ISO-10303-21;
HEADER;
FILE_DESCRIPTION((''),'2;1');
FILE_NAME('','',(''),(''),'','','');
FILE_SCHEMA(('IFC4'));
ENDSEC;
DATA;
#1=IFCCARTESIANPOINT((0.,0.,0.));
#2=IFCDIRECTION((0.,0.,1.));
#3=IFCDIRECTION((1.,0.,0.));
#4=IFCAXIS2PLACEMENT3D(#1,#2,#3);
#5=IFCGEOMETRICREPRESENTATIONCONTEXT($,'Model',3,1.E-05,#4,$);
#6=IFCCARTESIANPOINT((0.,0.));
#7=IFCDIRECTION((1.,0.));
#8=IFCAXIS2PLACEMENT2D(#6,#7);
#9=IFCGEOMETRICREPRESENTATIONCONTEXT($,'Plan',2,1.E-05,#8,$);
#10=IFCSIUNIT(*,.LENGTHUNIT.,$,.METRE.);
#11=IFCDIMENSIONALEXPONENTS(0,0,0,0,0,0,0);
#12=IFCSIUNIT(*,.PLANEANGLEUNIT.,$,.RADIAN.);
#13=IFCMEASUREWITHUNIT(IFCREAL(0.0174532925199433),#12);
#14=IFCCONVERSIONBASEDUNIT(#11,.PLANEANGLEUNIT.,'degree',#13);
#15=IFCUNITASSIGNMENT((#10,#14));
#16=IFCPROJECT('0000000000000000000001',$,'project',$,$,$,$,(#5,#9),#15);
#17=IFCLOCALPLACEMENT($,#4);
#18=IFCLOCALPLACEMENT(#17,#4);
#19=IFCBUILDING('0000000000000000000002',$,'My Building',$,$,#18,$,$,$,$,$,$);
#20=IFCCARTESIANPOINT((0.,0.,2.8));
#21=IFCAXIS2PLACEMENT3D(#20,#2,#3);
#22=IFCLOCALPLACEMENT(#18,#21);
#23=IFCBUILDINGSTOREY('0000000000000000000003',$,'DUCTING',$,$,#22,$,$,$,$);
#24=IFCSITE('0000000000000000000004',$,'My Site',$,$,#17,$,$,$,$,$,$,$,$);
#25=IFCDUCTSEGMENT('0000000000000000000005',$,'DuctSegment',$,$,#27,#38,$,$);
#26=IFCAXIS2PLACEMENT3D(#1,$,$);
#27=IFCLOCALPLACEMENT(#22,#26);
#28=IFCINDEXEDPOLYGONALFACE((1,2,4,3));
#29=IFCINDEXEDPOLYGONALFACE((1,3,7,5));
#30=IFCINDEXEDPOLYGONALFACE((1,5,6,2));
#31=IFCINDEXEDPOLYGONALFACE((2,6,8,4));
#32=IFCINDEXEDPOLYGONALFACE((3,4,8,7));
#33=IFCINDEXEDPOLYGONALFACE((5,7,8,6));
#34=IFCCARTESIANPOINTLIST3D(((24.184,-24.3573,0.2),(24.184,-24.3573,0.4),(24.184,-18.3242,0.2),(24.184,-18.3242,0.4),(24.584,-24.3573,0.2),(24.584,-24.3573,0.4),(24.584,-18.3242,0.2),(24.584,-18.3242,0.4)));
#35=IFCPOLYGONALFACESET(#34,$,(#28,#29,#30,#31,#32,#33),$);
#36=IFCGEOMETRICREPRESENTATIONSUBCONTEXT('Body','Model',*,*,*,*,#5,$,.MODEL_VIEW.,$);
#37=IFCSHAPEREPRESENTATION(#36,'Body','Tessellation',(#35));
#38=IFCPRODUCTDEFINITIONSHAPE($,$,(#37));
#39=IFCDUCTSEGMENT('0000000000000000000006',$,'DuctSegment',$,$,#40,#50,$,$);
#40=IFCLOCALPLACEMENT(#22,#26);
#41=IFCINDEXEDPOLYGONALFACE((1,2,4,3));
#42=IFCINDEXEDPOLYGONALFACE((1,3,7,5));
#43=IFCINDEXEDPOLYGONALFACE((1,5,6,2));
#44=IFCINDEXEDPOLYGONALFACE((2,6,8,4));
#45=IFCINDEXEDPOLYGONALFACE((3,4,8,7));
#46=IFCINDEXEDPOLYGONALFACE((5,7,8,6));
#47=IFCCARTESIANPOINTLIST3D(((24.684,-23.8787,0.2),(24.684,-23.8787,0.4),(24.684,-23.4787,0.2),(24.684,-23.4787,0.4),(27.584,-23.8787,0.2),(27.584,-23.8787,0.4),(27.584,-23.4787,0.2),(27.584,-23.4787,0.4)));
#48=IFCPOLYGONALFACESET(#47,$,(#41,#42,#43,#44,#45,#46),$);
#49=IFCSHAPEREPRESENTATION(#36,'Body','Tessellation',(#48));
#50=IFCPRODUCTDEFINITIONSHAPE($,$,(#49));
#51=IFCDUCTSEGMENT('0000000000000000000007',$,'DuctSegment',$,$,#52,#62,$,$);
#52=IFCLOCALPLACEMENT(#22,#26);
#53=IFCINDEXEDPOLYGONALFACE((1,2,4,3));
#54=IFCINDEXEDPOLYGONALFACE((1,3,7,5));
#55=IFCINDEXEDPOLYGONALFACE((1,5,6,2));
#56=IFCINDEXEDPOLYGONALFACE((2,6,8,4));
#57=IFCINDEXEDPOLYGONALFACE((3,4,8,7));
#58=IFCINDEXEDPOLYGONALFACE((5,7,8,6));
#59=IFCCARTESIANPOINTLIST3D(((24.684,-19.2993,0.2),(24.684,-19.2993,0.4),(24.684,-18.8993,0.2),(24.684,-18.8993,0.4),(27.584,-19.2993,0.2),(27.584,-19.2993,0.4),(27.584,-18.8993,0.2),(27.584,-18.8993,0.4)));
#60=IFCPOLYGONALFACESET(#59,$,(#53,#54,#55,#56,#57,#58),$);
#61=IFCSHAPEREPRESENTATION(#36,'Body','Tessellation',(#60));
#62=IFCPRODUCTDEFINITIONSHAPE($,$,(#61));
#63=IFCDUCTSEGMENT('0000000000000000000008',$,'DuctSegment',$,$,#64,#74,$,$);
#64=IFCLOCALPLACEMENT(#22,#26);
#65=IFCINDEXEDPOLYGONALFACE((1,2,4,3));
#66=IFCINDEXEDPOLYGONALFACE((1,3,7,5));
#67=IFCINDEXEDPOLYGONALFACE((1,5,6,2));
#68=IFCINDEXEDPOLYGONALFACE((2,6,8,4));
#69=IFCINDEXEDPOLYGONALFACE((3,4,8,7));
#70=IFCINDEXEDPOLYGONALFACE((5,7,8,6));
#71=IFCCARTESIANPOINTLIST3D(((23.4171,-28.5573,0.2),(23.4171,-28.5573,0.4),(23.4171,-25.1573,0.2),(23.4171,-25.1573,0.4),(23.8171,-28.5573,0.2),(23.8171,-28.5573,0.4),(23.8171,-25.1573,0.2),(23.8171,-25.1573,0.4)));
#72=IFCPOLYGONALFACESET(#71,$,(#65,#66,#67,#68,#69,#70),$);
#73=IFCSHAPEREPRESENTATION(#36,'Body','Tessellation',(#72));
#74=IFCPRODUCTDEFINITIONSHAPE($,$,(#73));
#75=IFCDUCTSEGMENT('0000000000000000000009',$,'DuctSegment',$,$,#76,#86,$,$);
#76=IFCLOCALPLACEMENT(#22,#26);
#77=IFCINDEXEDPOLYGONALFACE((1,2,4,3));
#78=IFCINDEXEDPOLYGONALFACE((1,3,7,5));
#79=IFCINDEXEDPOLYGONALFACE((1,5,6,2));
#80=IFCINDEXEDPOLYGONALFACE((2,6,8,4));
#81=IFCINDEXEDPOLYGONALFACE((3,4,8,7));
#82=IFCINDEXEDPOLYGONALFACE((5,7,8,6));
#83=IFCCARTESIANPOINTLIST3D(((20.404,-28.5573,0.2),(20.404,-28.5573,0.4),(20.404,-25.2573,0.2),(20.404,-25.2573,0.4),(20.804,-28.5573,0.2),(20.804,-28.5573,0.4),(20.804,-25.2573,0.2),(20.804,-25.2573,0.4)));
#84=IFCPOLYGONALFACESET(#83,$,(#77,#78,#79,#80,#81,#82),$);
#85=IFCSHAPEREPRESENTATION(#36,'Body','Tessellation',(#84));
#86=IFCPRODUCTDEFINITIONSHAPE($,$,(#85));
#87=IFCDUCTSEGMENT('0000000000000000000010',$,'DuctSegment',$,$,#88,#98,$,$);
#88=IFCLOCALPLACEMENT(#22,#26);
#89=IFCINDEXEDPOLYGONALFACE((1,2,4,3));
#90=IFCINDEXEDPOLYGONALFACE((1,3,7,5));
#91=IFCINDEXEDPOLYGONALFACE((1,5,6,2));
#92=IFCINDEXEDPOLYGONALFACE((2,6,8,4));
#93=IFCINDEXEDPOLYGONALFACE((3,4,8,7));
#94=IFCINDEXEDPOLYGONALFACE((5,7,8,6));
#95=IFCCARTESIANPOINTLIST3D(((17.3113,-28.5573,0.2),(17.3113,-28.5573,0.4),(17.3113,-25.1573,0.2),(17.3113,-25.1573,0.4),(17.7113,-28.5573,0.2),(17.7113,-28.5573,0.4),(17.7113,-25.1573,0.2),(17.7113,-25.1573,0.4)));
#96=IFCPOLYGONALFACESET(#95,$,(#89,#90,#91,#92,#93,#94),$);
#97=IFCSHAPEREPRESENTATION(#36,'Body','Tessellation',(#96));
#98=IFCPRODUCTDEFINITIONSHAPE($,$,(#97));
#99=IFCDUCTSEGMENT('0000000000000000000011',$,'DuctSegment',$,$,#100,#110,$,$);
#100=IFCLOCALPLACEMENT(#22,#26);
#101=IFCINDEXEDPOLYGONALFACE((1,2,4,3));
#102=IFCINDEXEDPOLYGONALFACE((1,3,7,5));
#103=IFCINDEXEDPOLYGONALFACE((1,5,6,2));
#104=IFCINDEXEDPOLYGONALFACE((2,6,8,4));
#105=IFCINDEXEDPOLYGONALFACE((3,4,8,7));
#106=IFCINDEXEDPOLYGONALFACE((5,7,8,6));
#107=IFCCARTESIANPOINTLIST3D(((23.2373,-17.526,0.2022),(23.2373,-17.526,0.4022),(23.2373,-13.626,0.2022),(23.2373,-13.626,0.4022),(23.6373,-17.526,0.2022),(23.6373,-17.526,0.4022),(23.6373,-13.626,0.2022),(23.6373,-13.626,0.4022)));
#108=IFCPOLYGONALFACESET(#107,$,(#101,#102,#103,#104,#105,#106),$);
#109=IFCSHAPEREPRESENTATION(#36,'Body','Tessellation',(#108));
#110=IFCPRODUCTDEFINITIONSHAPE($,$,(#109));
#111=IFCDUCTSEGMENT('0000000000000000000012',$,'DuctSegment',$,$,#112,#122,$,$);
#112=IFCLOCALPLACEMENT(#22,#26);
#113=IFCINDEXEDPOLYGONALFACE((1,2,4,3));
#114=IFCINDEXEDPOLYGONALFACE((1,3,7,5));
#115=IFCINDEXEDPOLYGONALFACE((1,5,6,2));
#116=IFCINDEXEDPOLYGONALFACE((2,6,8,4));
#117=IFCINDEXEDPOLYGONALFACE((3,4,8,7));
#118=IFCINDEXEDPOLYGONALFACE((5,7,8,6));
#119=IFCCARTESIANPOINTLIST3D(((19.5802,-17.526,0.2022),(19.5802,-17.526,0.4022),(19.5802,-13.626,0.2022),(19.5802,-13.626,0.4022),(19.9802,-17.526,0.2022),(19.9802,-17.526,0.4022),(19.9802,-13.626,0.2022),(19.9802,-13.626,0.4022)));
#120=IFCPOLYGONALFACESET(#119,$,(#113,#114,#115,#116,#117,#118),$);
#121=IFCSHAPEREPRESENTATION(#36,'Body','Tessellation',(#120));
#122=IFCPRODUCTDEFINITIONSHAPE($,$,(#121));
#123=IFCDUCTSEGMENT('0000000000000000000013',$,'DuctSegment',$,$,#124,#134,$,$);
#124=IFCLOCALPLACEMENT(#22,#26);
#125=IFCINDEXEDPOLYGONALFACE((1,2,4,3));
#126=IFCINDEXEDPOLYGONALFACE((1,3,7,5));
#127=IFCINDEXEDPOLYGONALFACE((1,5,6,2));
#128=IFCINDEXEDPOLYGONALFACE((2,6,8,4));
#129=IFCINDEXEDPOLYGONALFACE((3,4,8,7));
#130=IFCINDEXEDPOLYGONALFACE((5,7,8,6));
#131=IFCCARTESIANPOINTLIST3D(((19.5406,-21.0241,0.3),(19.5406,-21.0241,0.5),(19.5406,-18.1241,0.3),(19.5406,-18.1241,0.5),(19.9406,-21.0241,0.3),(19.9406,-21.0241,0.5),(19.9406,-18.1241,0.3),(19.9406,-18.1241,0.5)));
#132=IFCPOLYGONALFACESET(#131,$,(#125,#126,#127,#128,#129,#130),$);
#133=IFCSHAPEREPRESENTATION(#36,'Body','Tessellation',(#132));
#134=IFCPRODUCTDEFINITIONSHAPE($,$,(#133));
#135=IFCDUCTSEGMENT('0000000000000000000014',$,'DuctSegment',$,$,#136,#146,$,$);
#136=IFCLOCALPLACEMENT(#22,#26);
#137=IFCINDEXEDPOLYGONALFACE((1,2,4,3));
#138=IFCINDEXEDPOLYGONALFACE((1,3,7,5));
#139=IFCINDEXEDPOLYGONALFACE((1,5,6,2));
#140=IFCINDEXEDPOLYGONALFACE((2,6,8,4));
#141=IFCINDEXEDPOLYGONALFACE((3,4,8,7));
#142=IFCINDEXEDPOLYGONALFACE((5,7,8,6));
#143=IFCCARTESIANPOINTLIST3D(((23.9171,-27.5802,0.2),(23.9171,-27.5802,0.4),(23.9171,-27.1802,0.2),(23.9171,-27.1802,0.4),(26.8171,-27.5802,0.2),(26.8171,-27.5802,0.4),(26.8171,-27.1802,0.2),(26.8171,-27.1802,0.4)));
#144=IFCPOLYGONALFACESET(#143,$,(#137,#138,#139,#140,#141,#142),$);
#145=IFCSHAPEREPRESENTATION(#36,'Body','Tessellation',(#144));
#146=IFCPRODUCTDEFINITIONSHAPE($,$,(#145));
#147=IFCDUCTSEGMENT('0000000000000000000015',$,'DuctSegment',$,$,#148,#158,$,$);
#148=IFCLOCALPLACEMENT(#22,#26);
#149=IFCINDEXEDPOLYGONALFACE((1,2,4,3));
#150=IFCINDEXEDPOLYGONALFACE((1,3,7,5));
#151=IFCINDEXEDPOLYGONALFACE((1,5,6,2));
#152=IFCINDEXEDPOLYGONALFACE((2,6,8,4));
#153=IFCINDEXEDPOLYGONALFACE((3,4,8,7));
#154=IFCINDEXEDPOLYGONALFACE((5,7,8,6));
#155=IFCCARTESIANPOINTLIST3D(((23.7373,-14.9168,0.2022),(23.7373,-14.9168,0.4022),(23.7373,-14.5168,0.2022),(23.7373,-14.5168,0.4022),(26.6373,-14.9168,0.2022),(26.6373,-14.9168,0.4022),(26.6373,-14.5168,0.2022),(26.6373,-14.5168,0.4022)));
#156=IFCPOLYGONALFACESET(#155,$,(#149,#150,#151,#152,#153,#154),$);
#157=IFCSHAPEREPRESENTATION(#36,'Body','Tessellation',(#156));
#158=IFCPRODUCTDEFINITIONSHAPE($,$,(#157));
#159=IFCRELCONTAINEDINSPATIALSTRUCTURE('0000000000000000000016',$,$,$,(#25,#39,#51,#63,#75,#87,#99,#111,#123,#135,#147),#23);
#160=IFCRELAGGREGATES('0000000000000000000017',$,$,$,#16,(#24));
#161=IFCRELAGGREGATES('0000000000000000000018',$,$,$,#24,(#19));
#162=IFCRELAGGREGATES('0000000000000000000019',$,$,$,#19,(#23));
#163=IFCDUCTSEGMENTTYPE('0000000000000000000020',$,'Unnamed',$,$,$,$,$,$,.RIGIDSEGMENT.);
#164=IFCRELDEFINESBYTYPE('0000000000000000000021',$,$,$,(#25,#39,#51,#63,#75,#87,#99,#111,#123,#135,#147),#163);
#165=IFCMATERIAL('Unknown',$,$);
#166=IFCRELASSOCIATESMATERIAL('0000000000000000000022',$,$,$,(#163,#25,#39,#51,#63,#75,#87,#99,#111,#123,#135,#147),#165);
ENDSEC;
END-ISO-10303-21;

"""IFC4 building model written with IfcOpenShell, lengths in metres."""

from ifc_helpers import new_model, entity, si_unit, converted_unit, frame, origin_with_axes, origin_2d_with_axis, place, context, subcontext, project, spatial, rectangle, extrude, material, material_profile, profile_set, profile_usage, type_object, element, save


model = new_model("IFC4")

# Units and contexts
model_context = context("Model", 3, precision=1e-05, world=origin_with_axes())
plan_context = context("Plan", 2, precision=1e-05, world=origin_2d_with_axis())
body_context = subcontext(model_context, "Body", "Model", "MODEL_VIEW")
ifc_project = project(units=[si_unit("LENGTHUNIT", "METRE"), converted_unit("PLANEANGLEUNIT", "degree", entity("IfcReal", 0.0174532925199433), si_unit("PLANEANGLEUNIT", "RADIAN"), dimensions=[0, 0, 0, 0, 0, 0, 0])], contexts=[model_context, plan_context])

# Site, building, storey
site_placement = place(None, origin_with_axes())
site = spatial("IfcSite", under=ifc_project, at=site_placement, Name="My Site")
building_placement = place(site_placement, origin_with_axes())
building = spatial("IfcBuilding", under=site, at=building_placement, Name="My Building")
storey_placement = place(building_placement, frame((0.0, 0.0, 2.8), z_axis=(0.0, 0.0, 1.0), x_axis=(1.0, 0.0, 0.0)))
storey = spatial("IfcBuildingStorey", under=building, at=storey_placement, Name="DUCTING")

# Duct segments
ifc_material = material(Name="Unknown")
ifc_material_profile_1 = material_profile(ifc_material, rectangle(XDim=0.4, YDim=0.2))
ifc_profile_set_1 = profile_set([ifc_material_profile_1])
ifc_profile_usage_1 = profile_usage(ifc_profile_set_1, cardinal=5)
duct_segment_type = type_object("IfcDuctSegmentType", Name="Unnamed", PredefinedType="RIGIDSEGMENT", material=ifc_profile_set_1)
duct_segment_1_placement = place(storey_placement, frame((24.384, -18.3242, 0.3), z_axis=(0.0, -1.0, 0.0), x_axis=(1.0, 0.0, 0.0)))
element("IfcDuctSegment", 1, at=duct_segment_1_placement, inside=storey, type_object=duct_segment_type, material=ifc_profile_usage_1, Name="DuctSegment", context=body_context, shape_type="SweptSolid", body=[
    extrude(rectangle(XDim=0.4, YDim=0.2), origin_with_axes(), (0.0, 0.0, 1.0), 6.0332),
])
ifc_profile_usage_2 = profile_usage(ifc_profile_set_1, cardinal=5)
duct_segment_2_placement = place(storey_placement, frame((24.684, -23.6787, 0.3), z_axis=(1.0, 0.0, 0.0), x_axis=(0.0, 1.0, 0.0)))
element("IfcDuctSegment", 2, at=duct_segment_2_placement, inside=storey, type_object=duct_segment_type, material=ifc_profile_usage_2, Name="DuctSegment", context=body_context, shape_type="SweptSolid", body=[
    extrude(rectangle(XDim=0.4, YDim=0.2), origin_with_axes(), (0.0, 0.0, 1.0), 2.9),
])
ifc_profile_usage_3 = profile_usage(ifc_profile_set_1, cardinal=5)
duct_segment_3_placement = place(storey_placement, frame((24.684, -19.0993, 0.3), z_axis=(1.0, 0.0, 0.0), x_axis=(0.0, 1.0, 0.0)))
element("IfcDuctSegment", 3, at=duct_segment_3_placement, inside=storey, type_object=duct_segment_type, material=ifc_profile_usage_3, Name="DuctSegment", context=body_context, shape_type="SweptSolid", body=[
    extrude(rectangle(XDim=0.4, YDim=0.2), origin_with_axes(), (0.0, 0.0, 1.0), 2.9),
])
ifc_profile_usage_4 = profile_usage(ifc_profile_set_1, cardinal=5)
duct_segment_4_placement = place(storey_placement, frame((23.6171, -25.1573, 0.3), z_axis=(0.0, -1.0, 0.0), x_axis=(1.0, 0.0, 0.0)))
element("IfcDuctSegment", 4, at=duct_segment_4_placement, inside=storey, type_object=duct_segment_type, material=ifc_profile_usage_4, Name="DuctSegment", context=body_context, shape_type="SweptSolid", body=[
    extrude(rectangle(XDim=0.4, YDim=0.2), origin_with_axes(), (0.0, 0.0, 1.0), 3.4),
])
ifc_profile_usage_5 = profile_usage(ifc_profile_set_1, cardinal=5)
duct_segment_5_placement = place(storey_placement, frame((20.604, -25.2573, 0.3), z_axis=(0.0, -1.0, 0.0), x_axis=(1.0, 0.0, 0.0)))
element("IfcDuctSegment", 5, at=duct_segment_5_placement, inside=storey, type_object=duct_segment_type, material=ifc_profile_usage_5, Name="DuctSegment", context=body_context, shape_type="SweptSolid", body=[
    extrude(rectangle(XDim=0.4, YDim=0.2), origin_with_axes(), (0.0, 0.0, 1.0), 3.3),
])
ifc_profile_usage_6 = profile_usage(ifc_profile_set_1, cardinal=5)
duct_segment_6_placement = place(storey_placement, frame((17.5113, -25.1573, 0.3), z_axis=(0.0, -1.0, 0.0), x_axis=(1.0, 0.0, 0.0)))
element("IfcDuctSegment", 6, at=duct_segment_6_placement, inside=storey, type_object=duct_segment_type, material=ifc_profile_usage_6, Name="DuctSegment", context=body_context, shape_type="SweptSolid", body=[
    extrude(rectangle(XDim=0.4, YDim=0.2), origin_with_axes(), (0.0, 0.0, 1.0), 3.4),
])
ifc_profile_usage_7 = profile_usage(ifc_profile_set_1, cardinal=5)
duct_segment_7_placement = place(storey_placement, frame((23.4373, -13.626, 0.3022), z_axis=(0.0, -1.0, 0.000003), x_axis=(1.0, 0.0, 0.0)))
element("IfcDuctSegment", 7, at=duct_segment_7_placement, inside=storey, type_object=duct_segment_type, material=ifc_profile_usage_7, Name="DuctSegment", context=body_context, shape_type="SweptSolid", body=[
    extrude(rectangle(XDim=0.4, YDim=0.2), origin_with_axes(), (0.0, 0.0, 1.0), 3.9),
])
ifc_profile_usage_8 = profile_usage(ifc_profile_set_1, cardinal=5)
duct_segment_8_placement = place(storey_placement, frame((19.7802, -13.626, 0.3022), z_axis=(0.0, -1.0, 0.000003), x_axis=(1.0, 0.0, 0.0)))
element("IfcDuctSegment", 8, at=duct_segment_8_placement, inside=storey, type_object=duct_segment_type, material=ifc_profile_usage_8, Name="DuctSegment", context=body_context, shape_type="SweptSolid", body=[
    extrude(rectangle(XDim=0.4, YDim=0.2), origin_with_axes(), (0.0, 0.0, 1.0), 3.9),
])
ifc_profile_usage_9 = profile_usage(ifc_profile_set_1, cardinal=5)
duct_segment_9_placement = place(storey_placement, frame((19.7406, -18.1241, 0.4), z_axis=(0.0, -1.0, 0.000005), x_axis=(1.0, 0.0, 0.0)))
element("IfcDuctSegment", 9, at=duct_segment_9_placement, inside=storey, type_object=duct_segment_type, material=ifc_profile_usage_9, Name="DuctSegment", context=body_context, shape_type="SweptSolid", body=[
    extrude(rectangle(XDim=0.4, YDim=0.2), origin_with_axes(), (0.0, 0.0, 1.0), 2.9),
])
ifc_profile_usage_10 = profile_usage(ifc_profile_set_1, cardinal=5)
duct_segment_10_placement = place(storey_placement, frame((23.9171, -27.3802, 0.3), z_axis=(1.0, 0.0, 0.0), x_axis=(0.0, 1.0, 0.0)))
element("IfcDuctSegment", 10, at=duct_segment_10_placement, inside=storey, type_object=duct_segment_type, material=ifc_profile_usage_10, Name="DuctSegment", context=body_context, shape_type="SweptSolid", body=[
    extrude(rectangle(XDim=0.4, YDim=0.2), origin_with_axes(), (0.0, 0.0, 1.0), 2.9),
])
ifc_profile_usage_11 = profile_usage(ifc_profile_set_1, cardinal=5)
duct_segment_11_placement = place(storey_placement, frame((23.7373, -14.7168, 0.3022), z_axis=(1.0, 0.0, 0.0), x_axis=(0.0, 1.0, 0.0)))
element("IfcDuctSegment", 11, at=duct_segment_11_placement, inside=storey, type_object=duct_segment_type, material=ifc_profile_usage_11, Name="DuctSegment", context=body_context, shape_type="SweptSolid", body=[
    extrude(rectangle(XDim=0.4, YDim=0.2), origin_with_axes(), (0.0, 0.0, 1.0), 2.9),
])

save(model, "model.ifc")
